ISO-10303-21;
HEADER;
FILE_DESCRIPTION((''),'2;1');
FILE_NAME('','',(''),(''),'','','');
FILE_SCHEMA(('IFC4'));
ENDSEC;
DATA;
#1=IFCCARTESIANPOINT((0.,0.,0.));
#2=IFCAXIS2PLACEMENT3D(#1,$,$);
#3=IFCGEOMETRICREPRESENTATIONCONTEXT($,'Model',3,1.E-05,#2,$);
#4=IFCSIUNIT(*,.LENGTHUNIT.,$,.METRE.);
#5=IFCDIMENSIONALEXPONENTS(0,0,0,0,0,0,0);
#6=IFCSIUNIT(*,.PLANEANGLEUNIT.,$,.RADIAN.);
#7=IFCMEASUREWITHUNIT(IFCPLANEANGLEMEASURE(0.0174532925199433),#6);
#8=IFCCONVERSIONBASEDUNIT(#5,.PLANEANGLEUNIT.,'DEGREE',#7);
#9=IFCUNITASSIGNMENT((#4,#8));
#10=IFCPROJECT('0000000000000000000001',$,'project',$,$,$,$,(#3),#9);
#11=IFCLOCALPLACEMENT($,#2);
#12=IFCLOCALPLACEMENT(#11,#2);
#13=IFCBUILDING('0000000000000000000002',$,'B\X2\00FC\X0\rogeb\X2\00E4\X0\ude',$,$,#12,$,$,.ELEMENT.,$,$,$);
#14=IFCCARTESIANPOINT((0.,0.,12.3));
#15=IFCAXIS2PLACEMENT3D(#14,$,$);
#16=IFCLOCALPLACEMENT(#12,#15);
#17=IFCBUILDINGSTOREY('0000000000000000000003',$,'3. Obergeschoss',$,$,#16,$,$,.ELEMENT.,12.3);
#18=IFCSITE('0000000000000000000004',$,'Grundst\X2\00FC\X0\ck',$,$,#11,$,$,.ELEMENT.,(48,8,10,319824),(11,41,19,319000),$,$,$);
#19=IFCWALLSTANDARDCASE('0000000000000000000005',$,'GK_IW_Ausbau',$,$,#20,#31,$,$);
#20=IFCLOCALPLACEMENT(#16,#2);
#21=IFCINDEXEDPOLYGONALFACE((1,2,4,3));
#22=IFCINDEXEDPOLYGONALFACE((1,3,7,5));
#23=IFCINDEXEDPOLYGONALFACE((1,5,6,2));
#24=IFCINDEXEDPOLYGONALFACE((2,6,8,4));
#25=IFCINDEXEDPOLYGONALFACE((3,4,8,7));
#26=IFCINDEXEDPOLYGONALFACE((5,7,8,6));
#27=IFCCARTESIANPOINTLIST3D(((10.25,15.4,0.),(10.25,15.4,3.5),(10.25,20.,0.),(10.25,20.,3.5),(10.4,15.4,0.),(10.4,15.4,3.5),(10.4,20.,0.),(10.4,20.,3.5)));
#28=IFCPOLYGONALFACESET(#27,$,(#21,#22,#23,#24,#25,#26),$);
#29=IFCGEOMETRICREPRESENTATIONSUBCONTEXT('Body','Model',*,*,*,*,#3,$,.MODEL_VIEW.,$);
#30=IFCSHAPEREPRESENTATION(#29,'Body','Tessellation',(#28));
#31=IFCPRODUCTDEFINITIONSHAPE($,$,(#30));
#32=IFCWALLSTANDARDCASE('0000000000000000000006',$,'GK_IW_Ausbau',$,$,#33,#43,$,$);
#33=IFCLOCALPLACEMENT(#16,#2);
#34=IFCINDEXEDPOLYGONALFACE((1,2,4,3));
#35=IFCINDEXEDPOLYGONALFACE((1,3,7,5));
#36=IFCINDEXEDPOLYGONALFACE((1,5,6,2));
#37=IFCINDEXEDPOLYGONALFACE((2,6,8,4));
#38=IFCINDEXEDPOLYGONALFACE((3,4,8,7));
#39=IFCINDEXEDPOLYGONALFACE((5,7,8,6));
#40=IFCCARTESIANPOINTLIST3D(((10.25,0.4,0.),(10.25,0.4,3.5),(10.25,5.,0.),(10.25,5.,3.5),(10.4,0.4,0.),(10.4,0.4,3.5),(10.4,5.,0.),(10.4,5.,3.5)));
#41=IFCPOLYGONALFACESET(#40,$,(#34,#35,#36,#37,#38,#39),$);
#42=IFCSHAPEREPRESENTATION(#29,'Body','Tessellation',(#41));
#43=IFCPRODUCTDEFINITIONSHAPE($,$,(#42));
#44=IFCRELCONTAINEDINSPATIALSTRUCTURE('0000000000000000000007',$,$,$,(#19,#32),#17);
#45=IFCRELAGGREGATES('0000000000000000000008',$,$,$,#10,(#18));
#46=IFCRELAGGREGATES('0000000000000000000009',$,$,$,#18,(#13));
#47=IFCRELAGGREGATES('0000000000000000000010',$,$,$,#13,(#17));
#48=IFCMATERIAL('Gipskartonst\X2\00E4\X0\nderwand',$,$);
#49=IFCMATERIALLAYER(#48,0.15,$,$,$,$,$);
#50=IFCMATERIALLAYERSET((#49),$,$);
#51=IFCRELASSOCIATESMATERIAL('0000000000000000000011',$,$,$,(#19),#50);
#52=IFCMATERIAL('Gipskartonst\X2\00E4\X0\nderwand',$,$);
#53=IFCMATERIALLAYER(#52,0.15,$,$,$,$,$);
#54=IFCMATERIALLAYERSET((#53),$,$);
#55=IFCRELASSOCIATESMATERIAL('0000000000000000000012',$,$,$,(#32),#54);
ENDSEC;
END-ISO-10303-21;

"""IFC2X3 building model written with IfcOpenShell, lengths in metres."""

from ifc_helpers import new_model, entity, si_unit, converted_unit, frame, frame_2d, origin, origin_with_axes, place, context, subcontext, project, spatial, rectangle, extrude, material, layer, layer_set, layer_usage, element, save


model = new_model("IFC2X3")

# Units and contexts
model_context = context("Model", 3, precision=1e-05, world=origin())
body_context = subcontext(model_context, "Body", "Model", "MODEL_VIEW")
ifc_project = project(units=[si_unit("LENGTHUNIT", "METRE"), converted_unit("PLANEANGLEUNIT", "DEGREE", entity("IfcPlaneAngleMeasure", 0.0174532925199433), si_unit("PLANEANGLEUNIT", "RADIAN"), dimensions=[0, 0, 0, 0, 0, 0, 0])], contexts=[model_context])

# Site, building, storey
site_placement = place(None, origin())
site = spatial("IfcSite", under=ifc_project, at=site_placement, Name="Grundstück", CompositionType="ELEMENT", RefLatitude=(48, 8, 10, 319824), RefLongitude=(11, 41, 19, 319000))
building_placement = place(site_placement, origin())
building = spatial("IfcBuilding", under=site, at=building_placement, Name="Bürogebäude", CompositionType="ELEMENT")
storey_placement = place(building_placement, frame((0.0, 0.0, 12.3)))
storey = spatial("IfcBuildingStorey", under=building, at=storey_placement, Name="3. Obergeschoss", CompositionType="ELEMENT", Elevation=12.3)

# Walls
ifc_material_1 = material(Name="Gipskartonständerwand")
ifc_layer_1 = layer(ifc_material_1, 0.15)
ifc_layer_set_1 = layer_set([ifc_layer_1])
ifc_layer_usage_1 = layer_usage(ifc_layer_set_1, "AXIS2", "POSITIVE", -0.15)
wall_1_placement = place(storey_placement, frame((10.25, 20.0, 0.0), z_axis=(0.0, 0.0, 1.0), x_axis=(0.0, -1.0, 0.0)))
element("IfcWallStandardCase", 1, at=wall_1_placement, inside=storey, material=ifc_layer_usage_1, Name="GK_IW_Ausbau", context=body_context, shape_type="SweptSolid", body=[
    extrude(rectangle(XDim=4.6, YDim=0.15, at=frame_2d((2.3, 0.075), x_axis=(1.0, 0.0))), origin_with_axes(), (0.0, 0.0, 1.0), 3.5),
])
ifc_material_2 = material(Name="Gipskartonständerwand")
ifc_layer_2 = layer(ifc_material_2, 0.15)
ifc_layer_set_2 = layer_set([ifc_layer_2])
ifc_layer_usage_2 = layer_usage(ifc_layer_set_2, "AXIS2", "POSITIVE", -0.15)
wall_2_placement = place(storey_placement, frame((10.25, 5.0, 0.0), z_axis=(0.0, 0.0, 1.0), x_axis=(0.0, -1.0, 0.0)))
element("IfcWallStandardCase", 2, at=wall_2_placement, inside=storey, material=ifc_layer_usage_2, Name="GK_IW_Ausbau", context=body_context, shape_type="SweptSolid", body=[
    extrude(rectangle(XDim=4.6, YDim=0.15, at=frame_2d((2.3, 0.075), x_axis=(1.0, 0.0))), origin_with_axes(), (0.0, 0.0, 1.0), 3.5),
])

save(model, "model.ifc")
